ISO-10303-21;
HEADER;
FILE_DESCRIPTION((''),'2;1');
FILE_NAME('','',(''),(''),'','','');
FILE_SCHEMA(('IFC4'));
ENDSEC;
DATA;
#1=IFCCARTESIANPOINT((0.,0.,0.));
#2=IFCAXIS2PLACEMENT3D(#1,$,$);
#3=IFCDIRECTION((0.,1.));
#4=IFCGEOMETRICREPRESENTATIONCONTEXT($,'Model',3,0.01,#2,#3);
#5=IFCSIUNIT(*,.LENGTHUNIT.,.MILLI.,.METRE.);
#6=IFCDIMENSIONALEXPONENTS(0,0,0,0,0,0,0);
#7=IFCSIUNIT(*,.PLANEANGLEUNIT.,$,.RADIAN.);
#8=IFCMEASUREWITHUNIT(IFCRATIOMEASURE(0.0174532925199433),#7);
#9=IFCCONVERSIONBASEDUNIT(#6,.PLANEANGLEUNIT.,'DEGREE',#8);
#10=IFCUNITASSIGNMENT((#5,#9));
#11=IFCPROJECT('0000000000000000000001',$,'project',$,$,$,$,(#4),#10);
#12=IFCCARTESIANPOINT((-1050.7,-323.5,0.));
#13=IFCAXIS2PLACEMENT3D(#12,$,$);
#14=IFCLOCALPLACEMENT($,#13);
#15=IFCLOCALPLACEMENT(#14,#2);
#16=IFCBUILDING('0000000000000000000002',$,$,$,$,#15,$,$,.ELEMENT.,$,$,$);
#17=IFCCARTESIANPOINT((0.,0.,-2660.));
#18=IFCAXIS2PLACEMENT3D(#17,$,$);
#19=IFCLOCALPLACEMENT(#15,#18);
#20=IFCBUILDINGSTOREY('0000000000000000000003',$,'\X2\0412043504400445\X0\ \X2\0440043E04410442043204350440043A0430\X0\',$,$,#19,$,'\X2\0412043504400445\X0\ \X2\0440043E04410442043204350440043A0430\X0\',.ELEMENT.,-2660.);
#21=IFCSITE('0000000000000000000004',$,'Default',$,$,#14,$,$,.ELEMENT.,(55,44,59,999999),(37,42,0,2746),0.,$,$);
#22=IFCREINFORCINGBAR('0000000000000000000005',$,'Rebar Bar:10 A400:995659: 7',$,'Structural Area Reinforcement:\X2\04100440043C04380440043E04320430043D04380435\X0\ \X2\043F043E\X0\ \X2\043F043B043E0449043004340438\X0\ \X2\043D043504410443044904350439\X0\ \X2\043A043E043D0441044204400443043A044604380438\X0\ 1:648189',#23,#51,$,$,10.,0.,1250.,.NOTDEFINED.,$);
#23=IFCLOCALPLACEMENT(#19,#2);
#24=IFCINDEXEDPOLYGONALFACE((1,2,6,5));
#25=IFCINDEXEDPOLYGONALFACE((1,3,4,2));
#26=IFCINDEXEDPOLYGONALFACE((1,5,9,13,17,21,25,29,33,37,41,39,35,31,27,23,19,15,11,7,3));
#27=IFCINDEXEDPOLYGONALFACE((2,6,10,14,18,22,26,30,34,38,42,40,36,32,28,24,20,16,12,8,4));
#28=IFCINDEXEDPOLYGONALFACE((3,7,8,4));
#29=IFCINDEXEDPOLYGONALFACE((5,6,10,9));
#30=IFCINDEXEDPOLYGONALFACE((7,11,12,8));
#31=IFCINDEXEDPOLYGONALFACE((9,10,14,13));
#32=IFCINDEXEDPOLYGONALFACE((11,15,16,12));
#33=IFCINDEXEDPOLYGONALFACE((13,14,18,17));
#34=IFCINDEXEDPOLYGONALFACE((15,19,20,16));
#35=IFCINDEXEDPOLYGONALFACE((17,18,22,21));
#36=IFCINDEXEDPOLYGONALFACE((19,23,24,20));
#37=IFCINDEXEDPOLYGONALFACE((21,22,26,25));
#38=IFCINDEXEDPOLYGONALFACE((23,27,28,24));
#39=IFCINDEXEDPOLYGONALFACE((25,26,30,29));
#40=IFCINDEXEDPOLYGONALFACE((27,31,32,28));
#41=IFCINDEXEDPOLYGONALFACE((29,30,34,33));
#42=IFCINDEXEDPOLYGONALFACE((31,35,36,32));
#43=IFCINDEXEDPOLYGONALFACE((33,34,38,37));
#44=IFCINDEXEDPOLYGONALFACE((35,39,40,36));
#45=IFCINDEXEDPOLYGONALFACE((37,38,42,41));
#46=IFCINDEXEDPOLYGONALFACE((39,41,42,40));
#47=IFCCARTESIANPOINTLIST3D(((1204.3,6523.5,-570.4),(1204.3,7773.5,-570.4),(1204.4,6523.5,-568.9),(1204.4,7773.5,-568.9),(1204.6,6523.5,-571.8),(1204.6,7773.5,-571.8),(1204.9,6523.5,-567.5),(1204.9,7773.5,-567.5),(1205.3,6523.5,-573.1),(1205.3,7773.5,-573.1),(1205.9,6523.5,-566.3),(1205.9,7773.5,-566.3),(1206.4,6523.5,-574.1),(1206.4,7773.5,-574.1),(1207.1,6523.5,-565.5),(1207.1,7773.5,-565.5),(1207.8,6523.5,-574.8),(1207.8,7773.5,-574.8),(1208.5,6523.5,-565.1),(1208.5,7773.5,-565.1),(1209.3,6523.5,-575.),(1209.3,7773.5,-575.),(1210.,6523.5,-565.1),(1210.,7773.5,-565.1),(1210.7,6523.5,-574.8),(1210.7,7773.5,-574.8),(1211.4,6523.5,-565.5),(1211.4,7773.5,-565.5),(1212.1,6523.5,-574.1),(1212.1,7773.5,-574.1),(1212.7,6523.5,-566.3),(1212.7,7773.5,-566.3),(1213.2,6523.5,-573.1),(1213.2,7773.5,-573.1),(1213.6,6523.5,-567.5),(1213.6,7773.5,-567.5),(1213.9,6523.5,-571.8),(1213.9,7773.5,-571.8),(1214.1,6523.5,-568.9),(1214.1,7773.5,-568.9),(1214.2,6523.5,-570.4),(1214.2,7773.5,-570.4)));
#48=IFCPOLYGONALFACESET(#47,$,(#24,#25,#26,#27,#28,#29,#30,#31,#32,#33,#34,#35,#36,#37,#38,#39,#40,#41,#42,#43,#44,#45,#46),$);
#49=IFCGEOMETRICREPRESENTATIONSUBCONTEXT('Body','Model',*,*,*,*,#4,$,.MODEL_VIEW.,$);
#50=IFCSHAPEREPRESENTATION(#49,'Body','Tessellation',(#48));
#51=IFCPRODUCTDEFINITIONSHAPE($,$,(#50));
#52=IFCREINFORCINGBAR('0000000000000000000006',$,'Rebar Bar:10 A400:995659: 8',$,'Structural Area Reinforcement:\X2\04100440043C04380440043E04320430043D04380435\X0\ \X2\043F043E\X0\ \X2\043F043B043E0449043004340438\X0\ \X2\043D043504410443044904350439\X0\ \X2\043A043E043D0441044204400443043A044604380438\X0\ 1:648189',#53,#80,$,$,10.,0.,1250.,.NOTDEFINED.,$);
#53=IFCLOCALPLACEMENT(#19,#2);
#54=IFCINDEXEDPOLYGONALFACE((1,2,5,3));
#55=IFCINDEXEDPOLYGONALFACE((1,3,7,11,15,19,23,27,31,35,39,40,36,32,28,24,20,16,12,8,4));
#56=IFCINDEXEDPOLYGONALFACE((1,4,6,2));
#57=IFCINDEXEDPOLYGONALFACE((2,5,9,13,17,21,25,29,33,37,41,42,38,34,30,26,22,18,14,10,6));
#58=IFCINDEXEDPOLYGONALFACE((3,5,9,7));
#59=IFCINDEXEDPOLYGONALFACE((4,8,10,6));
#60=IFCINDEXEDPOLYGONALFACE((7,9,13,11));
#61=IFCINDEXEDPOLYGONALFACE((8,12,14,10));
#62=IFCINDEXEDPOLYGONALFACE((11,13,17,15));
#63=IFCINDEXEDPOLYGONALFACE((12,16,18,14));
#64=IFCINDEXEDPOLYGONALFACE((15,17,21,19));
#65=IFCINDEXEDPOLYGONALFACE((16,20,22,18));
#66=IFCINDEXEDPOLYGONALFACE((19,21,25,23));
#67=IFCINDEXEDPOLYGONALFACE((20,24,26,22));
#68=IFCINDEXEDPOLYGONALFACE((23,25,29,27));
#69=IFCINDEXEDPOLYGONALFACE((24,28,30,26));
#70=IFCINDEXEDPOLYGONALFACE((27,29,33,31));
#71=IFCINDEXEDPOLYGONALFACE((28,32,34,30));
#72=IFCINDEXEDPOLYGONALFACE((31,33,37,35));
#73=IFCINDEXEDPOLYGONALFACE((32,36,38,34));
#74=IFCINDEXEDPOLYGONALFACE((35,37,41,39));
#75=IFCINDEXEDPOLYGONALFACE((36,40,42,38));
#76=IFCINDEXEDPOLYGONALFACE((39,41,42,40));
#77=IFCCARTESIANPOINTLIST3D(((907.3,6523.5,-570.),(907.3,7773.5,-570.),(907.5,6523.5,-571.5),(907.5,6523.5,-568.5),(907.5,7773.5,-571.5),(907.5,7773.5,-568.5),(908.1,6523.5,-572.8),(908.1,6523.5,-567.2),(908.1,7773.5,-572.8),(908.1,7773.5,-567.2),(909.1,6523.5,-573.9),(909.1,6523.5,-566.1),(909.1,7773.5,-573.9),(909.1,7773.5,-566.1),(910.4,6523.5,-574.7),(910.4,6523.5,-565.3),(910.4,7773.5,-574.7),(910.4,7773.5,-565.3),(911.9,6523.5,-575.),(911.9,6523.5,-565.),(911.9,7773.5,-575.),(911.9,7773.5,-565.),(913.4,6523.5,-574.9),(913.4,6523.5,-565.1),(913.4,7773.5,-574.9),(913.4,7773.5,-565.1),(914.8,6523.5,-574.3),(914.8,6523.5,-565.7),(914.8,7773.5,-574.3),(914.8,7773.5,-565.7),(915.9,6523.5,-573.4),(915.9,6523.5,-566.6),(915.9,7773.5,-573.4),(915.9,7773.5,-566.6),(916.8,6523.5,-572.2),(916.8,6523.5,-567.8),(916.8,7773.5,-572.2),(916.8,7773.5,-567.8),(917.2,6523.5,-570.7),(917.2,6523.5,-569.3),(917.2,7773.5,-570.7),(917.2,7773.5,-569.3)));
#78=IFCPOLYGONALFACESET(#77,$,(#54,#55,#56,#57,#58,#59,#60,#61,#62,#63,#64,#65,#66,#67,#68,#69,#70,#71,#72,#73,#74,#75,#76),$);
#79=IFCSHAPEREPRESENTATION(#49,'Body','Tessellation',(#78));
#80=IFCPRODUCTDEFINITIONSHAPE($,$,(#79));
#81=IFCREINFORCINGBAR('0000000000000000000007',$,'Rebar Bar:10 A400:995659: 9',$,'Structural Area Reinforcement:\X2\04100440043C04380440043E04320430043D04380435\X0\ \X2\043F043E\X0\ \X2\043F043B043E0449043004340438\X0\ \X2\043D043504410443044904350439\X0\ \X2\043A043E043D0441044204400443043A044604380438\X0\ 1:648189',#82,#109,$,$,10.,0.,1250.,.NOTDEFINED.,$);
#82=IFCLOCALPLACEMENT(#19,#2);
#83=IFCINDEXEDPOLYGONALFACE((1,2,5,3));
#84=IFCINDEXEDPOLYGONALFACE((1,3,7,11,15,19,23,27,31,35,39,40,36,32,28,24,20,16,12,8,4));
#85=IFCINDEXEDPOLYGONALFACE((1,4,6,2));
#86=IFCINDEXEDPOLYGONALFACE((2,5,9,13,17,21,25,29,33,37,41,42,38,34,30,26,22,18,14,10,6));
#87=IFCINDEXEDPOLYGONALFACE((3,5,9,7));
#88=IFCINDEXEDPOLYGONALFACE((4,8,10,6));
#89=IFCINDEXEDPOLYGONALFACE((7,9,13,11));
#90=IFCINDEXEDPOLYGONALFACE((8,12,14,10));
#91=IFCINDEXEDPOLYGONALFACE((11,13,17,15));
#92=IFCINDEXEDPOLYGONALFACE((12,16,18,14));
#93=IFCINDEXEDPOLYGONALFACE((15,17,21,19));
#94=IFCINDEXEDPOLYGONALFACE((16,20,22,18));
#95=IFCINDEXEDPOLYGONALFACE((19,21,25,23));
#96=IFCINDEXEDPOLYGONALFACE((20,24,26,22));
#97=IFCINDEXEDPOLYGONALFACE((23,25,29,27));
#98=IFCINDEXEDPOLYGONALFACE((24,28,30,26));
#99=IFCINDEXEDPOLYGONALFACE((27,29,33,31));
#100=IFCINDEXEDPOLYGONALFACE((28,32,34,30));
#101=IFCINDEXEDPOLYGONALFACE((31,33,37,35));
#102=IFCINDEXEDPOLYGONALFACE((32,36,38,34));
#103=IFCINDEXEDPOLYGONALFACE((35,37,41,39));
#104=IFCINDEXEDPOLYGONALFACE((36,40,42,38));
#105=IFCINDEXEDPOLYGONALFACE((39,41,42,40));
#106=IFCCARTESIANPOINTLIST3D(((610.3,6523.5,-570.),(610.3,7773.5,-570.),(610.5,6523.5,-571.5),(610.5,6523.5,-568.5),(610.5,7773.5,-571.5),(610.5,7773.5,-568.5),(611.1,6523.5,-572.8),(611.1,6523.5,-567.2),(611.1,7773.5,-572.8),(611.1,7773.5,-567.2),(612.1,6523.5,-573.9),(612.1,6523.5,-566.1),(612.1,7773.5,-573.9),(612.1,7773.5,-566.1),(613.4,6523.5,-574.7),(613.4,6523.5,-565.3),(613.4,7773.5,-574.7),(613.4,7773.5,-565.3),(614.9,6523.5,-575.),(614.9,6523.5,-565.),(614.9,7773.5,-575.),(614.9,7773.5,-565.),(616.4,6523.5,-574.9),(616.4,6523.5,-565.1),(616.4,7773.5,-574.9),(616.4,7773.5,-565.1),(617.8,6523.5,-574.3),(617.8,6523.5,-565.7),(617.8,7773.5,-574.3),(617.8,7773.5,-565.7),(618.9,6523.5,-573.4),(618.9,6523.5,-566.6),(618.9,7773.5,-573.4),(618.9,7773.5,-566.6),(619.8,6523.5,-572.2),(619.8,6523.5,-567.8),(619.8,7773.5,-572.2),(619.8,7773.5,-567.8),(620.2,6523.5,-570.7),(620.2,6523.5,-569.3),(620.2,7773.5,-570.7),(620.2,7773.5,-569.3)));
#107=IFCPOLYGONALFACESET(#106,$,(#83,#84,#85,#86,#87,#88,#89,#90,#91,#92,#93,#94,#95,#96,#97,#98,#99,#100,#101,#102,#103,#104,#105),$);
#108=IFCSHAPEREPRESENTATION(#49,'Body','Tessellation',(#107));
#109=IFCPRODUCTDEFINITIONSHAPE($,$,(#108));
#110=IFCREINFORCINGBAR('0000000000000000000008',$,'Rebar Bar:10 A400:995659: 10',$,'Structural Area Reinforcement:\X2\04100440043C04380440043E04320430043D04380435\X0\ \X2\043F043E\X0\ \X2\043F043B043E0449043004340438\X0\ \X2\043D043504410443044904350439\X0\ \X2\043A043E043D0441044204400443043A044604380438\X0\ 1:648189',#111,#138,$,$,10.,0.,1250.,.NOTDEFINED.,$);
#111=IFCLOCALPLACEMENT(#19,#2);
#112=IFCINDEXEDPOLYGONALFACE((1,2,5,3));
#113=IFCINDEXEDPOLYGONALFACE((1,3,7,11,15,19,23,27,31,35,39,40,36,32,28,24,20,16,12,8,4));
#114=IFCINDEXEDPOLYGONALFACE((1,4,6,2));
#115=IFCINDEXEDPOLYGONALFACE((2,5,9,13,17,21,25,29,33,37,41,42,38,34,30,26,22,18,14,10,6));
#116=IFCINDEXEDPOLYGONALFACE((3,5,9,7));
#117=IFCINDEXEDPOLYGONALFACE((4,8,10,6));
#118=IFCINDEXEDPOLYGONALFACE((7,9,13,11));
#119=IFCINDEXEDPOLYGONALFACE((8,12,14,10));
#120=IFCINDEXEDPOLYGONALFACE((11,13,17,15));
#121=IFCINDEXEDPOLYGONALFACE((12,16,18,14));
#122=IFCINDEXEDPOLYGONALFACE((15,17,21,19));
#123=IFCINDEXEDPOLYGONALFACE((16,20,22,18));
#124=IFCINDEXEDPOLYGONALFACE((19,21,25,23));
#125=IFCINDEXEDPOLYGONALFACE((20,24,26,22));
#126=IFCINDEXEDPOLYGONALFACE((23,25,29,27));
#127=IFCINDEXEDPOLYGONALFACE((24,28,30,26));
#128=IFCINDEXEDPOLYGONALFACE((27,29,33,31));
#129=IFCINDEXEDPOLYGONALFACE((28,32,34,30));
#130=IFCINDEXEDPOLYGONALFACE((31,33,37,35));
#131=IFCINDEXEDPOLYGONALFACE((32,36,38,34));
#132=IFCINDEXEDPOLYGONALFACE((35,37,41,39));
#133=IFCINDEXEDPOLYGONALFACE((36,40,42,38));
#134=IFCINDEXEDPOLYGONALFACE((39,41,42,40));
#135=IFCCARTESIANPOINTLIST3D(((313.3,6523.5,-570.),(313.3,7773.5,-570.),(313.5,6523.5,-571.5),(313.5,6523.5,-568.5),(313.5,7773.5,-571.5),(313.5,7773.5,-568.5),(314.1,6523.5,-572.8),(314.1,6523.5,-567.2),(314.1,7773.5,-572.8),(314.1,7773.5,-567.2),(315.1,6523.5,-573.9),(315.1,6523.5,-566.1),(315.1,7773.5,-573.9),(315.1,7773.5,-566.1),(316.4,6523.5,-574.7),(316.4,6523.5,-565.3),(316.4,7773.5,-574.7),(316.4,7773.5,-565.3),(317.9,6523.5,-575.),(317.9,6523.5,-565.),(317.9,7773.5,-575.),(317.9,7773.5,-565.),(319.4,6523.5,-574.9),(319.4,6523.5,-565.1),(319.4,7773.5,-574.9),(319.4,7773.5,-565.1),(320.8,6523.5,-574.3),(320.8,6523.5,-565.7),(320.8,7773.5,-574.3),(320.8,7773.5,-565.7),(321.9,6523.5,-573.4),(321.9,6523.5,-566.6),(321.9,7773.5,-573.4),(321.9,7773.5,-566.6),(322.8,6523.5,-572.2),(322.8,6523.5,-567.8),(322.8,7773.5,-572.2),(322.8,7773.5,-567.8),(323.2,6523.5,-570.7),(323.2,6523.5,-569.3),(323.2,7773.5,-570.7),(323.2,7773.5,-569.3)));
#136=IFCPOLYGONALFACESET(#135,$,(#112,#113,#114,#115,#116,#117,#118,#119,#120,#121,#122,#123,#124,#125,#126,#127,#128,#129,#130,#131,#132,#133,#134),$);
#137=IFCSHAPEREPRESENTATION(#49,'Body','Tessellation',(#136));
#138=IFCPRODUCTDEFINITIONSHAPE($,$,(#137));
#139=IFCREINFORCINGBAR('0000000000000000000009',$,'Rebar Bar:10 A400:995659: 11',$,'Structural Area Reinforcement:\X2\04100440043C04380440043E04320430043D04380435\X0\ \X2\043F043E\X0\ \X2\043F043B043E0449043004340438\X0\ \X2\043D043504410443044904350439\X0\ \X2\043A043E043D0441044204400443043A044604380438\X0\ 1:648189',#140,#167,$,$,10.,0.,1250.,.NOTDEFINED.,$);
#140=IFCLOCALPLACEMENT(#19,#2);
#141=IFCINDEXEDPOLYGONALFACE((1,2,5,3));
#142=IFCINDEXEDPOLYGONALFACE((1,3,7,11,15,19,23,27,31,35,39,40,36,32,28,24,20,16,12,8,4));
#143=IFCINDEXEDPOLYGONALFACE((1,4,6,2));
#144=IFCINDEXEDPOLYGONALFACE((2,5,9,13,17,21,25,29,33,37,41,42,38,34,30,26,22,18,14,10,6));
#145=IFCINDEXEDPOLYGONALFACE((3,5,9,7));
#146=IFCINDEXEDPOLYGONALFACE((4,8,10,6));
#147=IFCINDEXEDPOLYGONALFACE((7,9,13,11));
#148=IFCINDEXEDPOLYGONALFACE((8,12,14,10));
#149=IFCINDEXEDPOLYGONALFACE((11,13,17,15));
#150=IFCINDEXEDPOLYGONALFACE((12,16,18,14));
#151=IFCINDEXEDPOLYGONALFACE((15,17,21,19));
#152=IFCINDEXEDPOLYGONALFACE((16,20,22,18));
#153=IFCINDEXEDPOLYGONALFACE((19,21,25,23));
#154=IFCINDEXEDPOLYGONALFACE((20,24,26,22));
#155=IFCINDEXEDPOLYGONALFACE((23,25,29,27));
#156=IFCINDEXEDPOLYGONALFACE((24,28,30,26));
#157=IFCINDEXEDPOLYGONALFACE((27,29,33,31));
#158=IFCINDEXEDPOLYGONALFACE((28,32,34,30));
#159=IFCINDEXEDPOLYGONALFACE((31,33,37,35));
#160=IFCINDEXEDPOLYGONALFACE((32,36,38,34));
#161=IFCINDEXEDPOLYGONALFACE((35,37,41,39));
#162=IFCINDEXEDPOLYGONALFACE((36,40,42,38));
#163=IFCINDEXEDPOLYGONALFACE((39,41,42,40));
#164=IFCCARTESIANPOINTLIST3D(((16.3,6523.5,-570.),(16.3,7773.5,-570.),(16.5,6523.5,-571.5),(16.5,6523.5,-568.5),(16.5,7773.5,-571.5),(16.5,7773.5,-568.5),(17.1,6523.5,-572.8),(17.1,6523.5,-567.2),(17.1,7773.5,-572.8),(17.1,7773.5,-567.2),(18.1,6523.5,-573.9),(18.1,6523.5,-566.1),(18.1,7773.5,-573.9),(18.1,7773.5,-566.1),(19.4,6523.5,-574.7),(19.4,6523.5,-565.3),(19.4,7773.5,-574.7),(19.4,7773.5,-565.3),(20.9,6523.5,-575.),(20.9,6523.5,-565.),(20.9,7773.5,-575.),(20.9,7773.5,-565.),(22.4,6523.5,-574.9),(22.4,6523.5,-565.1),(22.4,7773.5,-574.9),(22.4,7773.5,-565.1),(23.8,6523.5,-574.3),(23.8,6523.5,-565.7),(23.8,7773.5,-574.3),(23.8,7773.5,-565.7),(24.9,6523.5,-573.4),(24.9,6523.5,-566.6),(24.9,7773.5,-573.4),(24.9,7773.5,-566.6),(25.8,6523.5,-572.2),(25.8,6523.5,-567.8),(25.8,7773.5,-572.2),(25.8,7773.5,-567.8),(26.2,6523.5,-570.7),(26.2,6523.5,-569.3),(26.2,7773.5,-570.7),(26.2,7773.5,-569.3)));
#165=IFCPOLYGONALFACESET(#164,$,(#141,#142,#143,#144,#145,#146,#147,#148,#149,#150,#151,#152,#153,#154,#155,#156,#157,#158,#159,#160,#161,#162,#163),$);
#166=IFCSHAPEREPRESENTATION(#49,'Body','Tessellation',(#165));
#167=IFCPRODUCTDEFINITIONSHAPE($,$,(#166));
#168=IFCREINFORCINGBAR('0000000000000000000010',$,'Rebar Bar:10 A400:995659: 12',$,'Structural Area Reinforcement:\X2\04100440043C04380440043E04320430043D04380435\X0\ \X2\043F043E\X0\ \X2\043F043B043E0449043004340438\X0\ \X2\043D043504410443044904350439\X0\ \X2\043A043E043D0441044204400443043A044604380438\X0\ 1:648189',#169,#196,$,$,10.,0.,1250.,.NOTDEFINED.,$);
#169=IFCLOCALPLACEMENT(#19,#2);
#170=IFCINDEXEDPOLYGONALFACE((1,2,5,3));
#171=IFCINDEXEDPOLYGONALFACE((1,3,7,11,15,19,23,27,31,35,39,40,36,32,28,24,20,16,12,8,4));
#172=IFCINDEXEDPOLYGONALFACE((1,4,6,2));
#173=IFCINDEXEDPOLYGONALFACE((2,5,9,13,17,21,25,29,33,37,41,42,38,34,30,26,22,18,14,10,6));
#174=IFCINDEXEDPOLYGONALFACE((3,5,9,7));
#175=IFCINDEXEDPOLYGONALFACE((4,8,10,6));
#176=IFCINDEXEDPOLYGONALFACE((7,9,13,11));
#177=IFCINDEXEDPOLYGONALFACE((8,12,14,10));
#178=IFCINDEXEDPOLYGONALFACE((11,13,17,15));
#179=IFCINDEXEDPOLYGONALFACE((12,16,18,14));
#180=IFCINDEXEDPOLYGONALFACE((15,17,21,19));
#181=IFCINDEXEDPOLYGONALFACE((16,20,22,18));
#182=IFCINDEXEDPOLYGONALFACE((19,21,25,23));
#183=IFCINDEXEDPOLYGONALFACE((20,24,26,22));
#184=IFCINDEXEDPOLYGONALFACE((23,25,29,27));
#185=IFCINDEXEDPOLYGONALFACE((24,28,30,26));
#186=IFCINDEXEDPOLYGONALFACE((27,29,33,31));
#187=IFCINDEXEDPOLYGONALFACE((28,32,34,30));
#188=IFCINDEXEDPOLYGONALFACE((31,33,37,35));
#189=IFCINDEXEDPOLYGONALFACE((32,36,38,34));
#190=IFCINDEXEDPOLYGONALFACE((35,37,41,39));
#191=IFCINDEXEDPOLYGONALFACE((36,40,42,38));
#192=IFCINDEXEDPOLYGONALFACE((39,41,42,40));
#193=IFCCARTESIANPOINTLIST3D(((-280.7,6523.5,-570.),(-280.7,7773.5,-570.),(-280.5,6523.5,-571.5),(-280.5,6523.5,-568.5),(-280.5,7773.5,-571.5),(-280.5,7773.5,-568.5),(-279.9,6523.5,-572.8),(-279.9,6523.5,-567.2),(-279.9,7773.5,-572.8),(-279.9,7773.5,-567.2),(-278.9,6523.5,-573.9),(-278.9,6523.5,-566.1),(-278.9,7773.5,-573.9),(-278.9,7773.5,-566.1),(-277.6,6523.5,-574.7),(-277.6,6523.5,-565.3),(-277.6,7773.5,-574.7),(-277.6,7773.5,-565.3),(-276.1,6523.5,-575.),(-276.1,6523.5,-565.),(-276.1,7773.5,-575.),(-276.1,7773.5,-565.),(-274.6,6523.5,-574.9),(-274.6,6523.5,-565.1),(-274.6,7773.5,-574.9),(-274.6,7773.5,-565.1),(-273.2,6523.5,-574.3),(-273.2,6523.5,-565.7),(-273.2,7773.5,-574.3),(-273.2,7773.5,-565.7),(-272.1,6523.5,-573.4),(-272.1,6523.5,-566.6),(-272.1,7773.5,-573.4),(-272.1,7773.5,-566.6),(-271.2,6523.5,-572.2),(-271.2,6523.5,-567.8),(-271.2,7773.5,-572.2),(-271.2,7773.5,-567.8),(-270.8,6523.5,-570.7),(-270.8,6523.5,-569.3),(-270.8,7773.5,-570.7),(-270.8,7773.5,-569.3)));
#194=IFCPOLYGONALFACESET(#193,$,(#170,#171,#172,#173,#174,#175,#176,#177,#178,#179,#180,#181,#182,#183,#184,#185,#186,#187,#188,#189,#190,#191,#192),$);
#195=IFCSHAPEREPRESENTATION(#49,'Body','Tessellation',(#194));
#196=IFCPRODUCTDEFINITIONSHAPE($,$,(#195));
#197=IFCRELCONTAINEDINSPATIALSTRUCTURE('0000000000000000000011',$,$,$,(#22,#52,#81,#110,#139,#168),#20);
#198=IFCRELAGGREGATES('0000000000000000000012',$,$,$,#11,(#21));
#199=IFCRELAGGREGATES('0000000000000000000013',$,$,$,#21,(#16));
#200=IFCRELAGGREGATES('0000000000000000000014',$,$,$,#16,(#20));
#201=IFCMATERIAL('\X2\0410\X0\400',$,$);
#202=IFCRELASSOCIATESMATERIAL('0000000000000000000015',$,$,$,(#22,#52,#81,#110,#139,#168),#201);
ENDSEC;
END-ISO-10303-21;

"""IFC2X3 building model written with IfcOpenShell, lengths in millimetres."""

from ifc_helpers import new_model, entity, si_unit, converted_unit, direction, frame, origin, place, context, subcontext, project, spatial, material, element, save


model = new_model("IFC2X3")

# Units and contexts
model_context = context("Model", 3, precision=0.01, world=origin(), true_north=direction((0.0, 1.0)))
body_context = subcontext(model_context, "Body", "Model", "MODEL_VIEW")
ifc_project = project(units=[si_unit("LENGTHUNIT", "METRE", prefix="MILLI"), converted_unit("PLANEANGLEUNIT", "DEGREE", entity("IfcRatioMeasure", 0.0174532925199433), si_unit("PLANEANGLEUNIT", "RADIAN"), dimensions=[0, 0, 0, 0, 0, 0, 0])], contexts=[model_context])

# Site, building, storey
site_placement = place(None, frame((-1050.7, -323.5, 0.0)))
site = spatial("IfcSite", under=ifc_project, at=site_placement, Name="Default", CompositionType="ELEMENT", RefLatitude=(55, 44, 59, 999999), RefLongitude=(37, 42, 0, 2746), RefElevation=0.0)
building_placement = place(site_placement, origin())
building = spatial("IfcBuilding", under=site, at=building_placement, CompositionType="ELEMENT")
storey_placement = place(building_placement, frame((0.0, 0.0, -2660.0)))
storey = spatial("IfcBuildingStorey", under=building, at=storey_placement, Name="Верх ростверка", LongName="Верх ростверка", CompositionType="ELEMENT", Elevation=-2660.0)

# Reinforcing bars
ifc_material = material(Name="А400")
reinforcing_bar_1_placement = place(storey_placement, origin())
element("IfcReinforcingBar", 1, at=reinforcing_bar_1_placement, inside=storey, material=ifc_material, Name="Rebar Bar:10 A400:995659: 7", ObjectType="Structural Area Reinforcement:Армирование по площади несущей конструкции 1:648189", BarLength=1250.0, BarRole="NOTDEFINED", CrossSectionArea=0.0, NominalDiameter=10.0, context=body_context, shape_type="AdvancedSweptSolid", body=[
    entity("IfcSweptDiskSolid", entity("IfcCompositeCurve", [entity("IfcCompositeCurveSegment", "CONTINUOUS", True, entity("IfcPolyline", [entity("IfcCartesianPoint", [1209.3, 7773.5, -570.0]), entity("IfcCartesianPoint", [1209.3, 6523.5, -570.0])]))], False), 5.0, None, 0.0, 1.0),
])
reinforcing_bar_2_placement = place(storey_placement, origin())
element("IfcReinforcingBar", 2, at=reinforcing_bar_2_placement, inside=storey, material=ifc_material, Name="Rebar Bar:10 A400:995659: 8", ObjectType="Structural Area Reinforcement:Армирование по площади несущей конструкции 1:648189", BarLength=1250.0, BarRole="NOTDEFINED", CrossSectionArea=0.0, NominalDiameter=10.0, context=body_context, shape_type="AdvancedSweptSolid", body=[
    entity("IfcSweptDiskSolid", entity("IfcCompositeCurve", [entity("IfcCompositeCurveSegment", "CONTINUOUS", True, entity("IfcPolyline", [entity("IfcCartesianPoint", [912.3, 7773.5, -570.0]), entity("IfcCartesianPoint", [912.3, 6523.5, -570.0])]))], False), 5.0, None, 0.0, 1.0),
])
reinforcing_bar_3_placement = place(storey_placement, origin())
element("IfcReinforcingBar", 3, at=reinforcing_bar_3_placement, inside=storey, material=ifc_material, Name="Rebar Bar:10 A400:995659: 9", ObjectType="Structural Area Reinforcement:Армирование по площади несущей конструкции 1:648189", BarLength=1250.0, BarRole="NOTDEFINED", CrossSectionArea=0.0, NominalDiameter=10.0, context=body_context, shape_type="AdvancedSweptSolid", body=[
    entity("IfcSweptDiskSolid", entity("IfcCompositeCurve", [entity("IfcCompositeCurveSegment", "CONTINUOUS", True, entity("IfcPolyline", [entity("IfcCartesianPoint", [615.3, 7773.5, -570.0]), entity("IfcCartesianPoint", [615.3, 6523.5, -570.0])]))], False), 5.0, None, 0.0, 1.0),
])
reinforcing_bar_4_placement = place(storey_placement, origin())
element("IfcReinforcingBar", 4, at=reinforcing_bar_4_placement, inside=storey, material=ifc_material, Name="Rebar Bar:10 A400:995659: 10", ObjectType="Structural Area Reinforcement:Армирование по площади несущей конструкции 1:648189", BarLength=1250.0, BarRole="NOTDEFINED", CrossSectionArea=0.0, NominalDiameter=10.0, context=body_context, shape_type="AdvancedSweptSolid", body=[
    entity("IfcSweptDiskSolid", entity("IfcCompositeCurve", [entity("IfcCompositeCurveSegment", "CONTINUOUS", True, entity("IfcPolyline", [entity("IfcCartesianPoint", [318.3, 7773.5, -570.0]), entity("IfcCartesianPoint", [318.3, 6523.5, -570.0])]))], False), 5.0, None, 0.0, 1.0),
])
reinforcing_bar_5_placement = place(storey_placement, origin())
element("IfcReinforcingBar", 5, at=reinforcing_bar_5_placement, inside=storey, material=ifc_material, Name="Rebar Bar:10 A400:995659: 11", ObjectType="Structural Area Reinforcement:Армирование по площади несущей конструкции 1:648189", BarLength=1250.0, BarRole="NOTDEFINED", CrossSectionArea=0.0, NominalDiameter=10.0, context=body_context, shape_type="AdvancedSweptSolid", body=[
    entity("IfcSweptDiskSolid", entity("IfcCompositeCurve", [entity("IfcCompositeCurveSegment", "CONTINUOUS", True, entity("IfcPolyline", [entity("IfcCartesianPoint", [21.3, 7773.5, -570.0]), entity("IfcCartesianPoint", [21.3, 6523.5, -570.0])]))], False), 5.0, None, 0.0, 1.0),
])
reinforcing_bar_6_placement = place(storey_placement, origin())
element("IfcReinforcingBar", 6, at=reinforcing_bar_6_placement, inside=storey, material=ifc_material, Name="Rebar Bar:10 A400:995659: 12", ObjectType="Structural Area Reinforcement:Армирование по площади несущей конструкции 1:648189", BarLength=1250.0, BarRole="NOTDEFINED", CrossSectionArea=0.0, NominalDiameter=10.0, context=body_context, shape_type="AdvancedSweptSolid", body=[
    entity("IfcSweptDiskSolid", entity("IfcCompositeCurve", [entity("IfcCompositeCurveSegment", "CONTINUOUS", True, entity("IfcPolyline", [entity("IfcCartesianPoint", [-275.7, 7773.5, -570.0]), entity("IfcCartesianPoint", [-275.7, 6523.5, -570.0])]))], False), 5.0, None, 0.0, 1.0),
])

save(model, "model.ifc")
